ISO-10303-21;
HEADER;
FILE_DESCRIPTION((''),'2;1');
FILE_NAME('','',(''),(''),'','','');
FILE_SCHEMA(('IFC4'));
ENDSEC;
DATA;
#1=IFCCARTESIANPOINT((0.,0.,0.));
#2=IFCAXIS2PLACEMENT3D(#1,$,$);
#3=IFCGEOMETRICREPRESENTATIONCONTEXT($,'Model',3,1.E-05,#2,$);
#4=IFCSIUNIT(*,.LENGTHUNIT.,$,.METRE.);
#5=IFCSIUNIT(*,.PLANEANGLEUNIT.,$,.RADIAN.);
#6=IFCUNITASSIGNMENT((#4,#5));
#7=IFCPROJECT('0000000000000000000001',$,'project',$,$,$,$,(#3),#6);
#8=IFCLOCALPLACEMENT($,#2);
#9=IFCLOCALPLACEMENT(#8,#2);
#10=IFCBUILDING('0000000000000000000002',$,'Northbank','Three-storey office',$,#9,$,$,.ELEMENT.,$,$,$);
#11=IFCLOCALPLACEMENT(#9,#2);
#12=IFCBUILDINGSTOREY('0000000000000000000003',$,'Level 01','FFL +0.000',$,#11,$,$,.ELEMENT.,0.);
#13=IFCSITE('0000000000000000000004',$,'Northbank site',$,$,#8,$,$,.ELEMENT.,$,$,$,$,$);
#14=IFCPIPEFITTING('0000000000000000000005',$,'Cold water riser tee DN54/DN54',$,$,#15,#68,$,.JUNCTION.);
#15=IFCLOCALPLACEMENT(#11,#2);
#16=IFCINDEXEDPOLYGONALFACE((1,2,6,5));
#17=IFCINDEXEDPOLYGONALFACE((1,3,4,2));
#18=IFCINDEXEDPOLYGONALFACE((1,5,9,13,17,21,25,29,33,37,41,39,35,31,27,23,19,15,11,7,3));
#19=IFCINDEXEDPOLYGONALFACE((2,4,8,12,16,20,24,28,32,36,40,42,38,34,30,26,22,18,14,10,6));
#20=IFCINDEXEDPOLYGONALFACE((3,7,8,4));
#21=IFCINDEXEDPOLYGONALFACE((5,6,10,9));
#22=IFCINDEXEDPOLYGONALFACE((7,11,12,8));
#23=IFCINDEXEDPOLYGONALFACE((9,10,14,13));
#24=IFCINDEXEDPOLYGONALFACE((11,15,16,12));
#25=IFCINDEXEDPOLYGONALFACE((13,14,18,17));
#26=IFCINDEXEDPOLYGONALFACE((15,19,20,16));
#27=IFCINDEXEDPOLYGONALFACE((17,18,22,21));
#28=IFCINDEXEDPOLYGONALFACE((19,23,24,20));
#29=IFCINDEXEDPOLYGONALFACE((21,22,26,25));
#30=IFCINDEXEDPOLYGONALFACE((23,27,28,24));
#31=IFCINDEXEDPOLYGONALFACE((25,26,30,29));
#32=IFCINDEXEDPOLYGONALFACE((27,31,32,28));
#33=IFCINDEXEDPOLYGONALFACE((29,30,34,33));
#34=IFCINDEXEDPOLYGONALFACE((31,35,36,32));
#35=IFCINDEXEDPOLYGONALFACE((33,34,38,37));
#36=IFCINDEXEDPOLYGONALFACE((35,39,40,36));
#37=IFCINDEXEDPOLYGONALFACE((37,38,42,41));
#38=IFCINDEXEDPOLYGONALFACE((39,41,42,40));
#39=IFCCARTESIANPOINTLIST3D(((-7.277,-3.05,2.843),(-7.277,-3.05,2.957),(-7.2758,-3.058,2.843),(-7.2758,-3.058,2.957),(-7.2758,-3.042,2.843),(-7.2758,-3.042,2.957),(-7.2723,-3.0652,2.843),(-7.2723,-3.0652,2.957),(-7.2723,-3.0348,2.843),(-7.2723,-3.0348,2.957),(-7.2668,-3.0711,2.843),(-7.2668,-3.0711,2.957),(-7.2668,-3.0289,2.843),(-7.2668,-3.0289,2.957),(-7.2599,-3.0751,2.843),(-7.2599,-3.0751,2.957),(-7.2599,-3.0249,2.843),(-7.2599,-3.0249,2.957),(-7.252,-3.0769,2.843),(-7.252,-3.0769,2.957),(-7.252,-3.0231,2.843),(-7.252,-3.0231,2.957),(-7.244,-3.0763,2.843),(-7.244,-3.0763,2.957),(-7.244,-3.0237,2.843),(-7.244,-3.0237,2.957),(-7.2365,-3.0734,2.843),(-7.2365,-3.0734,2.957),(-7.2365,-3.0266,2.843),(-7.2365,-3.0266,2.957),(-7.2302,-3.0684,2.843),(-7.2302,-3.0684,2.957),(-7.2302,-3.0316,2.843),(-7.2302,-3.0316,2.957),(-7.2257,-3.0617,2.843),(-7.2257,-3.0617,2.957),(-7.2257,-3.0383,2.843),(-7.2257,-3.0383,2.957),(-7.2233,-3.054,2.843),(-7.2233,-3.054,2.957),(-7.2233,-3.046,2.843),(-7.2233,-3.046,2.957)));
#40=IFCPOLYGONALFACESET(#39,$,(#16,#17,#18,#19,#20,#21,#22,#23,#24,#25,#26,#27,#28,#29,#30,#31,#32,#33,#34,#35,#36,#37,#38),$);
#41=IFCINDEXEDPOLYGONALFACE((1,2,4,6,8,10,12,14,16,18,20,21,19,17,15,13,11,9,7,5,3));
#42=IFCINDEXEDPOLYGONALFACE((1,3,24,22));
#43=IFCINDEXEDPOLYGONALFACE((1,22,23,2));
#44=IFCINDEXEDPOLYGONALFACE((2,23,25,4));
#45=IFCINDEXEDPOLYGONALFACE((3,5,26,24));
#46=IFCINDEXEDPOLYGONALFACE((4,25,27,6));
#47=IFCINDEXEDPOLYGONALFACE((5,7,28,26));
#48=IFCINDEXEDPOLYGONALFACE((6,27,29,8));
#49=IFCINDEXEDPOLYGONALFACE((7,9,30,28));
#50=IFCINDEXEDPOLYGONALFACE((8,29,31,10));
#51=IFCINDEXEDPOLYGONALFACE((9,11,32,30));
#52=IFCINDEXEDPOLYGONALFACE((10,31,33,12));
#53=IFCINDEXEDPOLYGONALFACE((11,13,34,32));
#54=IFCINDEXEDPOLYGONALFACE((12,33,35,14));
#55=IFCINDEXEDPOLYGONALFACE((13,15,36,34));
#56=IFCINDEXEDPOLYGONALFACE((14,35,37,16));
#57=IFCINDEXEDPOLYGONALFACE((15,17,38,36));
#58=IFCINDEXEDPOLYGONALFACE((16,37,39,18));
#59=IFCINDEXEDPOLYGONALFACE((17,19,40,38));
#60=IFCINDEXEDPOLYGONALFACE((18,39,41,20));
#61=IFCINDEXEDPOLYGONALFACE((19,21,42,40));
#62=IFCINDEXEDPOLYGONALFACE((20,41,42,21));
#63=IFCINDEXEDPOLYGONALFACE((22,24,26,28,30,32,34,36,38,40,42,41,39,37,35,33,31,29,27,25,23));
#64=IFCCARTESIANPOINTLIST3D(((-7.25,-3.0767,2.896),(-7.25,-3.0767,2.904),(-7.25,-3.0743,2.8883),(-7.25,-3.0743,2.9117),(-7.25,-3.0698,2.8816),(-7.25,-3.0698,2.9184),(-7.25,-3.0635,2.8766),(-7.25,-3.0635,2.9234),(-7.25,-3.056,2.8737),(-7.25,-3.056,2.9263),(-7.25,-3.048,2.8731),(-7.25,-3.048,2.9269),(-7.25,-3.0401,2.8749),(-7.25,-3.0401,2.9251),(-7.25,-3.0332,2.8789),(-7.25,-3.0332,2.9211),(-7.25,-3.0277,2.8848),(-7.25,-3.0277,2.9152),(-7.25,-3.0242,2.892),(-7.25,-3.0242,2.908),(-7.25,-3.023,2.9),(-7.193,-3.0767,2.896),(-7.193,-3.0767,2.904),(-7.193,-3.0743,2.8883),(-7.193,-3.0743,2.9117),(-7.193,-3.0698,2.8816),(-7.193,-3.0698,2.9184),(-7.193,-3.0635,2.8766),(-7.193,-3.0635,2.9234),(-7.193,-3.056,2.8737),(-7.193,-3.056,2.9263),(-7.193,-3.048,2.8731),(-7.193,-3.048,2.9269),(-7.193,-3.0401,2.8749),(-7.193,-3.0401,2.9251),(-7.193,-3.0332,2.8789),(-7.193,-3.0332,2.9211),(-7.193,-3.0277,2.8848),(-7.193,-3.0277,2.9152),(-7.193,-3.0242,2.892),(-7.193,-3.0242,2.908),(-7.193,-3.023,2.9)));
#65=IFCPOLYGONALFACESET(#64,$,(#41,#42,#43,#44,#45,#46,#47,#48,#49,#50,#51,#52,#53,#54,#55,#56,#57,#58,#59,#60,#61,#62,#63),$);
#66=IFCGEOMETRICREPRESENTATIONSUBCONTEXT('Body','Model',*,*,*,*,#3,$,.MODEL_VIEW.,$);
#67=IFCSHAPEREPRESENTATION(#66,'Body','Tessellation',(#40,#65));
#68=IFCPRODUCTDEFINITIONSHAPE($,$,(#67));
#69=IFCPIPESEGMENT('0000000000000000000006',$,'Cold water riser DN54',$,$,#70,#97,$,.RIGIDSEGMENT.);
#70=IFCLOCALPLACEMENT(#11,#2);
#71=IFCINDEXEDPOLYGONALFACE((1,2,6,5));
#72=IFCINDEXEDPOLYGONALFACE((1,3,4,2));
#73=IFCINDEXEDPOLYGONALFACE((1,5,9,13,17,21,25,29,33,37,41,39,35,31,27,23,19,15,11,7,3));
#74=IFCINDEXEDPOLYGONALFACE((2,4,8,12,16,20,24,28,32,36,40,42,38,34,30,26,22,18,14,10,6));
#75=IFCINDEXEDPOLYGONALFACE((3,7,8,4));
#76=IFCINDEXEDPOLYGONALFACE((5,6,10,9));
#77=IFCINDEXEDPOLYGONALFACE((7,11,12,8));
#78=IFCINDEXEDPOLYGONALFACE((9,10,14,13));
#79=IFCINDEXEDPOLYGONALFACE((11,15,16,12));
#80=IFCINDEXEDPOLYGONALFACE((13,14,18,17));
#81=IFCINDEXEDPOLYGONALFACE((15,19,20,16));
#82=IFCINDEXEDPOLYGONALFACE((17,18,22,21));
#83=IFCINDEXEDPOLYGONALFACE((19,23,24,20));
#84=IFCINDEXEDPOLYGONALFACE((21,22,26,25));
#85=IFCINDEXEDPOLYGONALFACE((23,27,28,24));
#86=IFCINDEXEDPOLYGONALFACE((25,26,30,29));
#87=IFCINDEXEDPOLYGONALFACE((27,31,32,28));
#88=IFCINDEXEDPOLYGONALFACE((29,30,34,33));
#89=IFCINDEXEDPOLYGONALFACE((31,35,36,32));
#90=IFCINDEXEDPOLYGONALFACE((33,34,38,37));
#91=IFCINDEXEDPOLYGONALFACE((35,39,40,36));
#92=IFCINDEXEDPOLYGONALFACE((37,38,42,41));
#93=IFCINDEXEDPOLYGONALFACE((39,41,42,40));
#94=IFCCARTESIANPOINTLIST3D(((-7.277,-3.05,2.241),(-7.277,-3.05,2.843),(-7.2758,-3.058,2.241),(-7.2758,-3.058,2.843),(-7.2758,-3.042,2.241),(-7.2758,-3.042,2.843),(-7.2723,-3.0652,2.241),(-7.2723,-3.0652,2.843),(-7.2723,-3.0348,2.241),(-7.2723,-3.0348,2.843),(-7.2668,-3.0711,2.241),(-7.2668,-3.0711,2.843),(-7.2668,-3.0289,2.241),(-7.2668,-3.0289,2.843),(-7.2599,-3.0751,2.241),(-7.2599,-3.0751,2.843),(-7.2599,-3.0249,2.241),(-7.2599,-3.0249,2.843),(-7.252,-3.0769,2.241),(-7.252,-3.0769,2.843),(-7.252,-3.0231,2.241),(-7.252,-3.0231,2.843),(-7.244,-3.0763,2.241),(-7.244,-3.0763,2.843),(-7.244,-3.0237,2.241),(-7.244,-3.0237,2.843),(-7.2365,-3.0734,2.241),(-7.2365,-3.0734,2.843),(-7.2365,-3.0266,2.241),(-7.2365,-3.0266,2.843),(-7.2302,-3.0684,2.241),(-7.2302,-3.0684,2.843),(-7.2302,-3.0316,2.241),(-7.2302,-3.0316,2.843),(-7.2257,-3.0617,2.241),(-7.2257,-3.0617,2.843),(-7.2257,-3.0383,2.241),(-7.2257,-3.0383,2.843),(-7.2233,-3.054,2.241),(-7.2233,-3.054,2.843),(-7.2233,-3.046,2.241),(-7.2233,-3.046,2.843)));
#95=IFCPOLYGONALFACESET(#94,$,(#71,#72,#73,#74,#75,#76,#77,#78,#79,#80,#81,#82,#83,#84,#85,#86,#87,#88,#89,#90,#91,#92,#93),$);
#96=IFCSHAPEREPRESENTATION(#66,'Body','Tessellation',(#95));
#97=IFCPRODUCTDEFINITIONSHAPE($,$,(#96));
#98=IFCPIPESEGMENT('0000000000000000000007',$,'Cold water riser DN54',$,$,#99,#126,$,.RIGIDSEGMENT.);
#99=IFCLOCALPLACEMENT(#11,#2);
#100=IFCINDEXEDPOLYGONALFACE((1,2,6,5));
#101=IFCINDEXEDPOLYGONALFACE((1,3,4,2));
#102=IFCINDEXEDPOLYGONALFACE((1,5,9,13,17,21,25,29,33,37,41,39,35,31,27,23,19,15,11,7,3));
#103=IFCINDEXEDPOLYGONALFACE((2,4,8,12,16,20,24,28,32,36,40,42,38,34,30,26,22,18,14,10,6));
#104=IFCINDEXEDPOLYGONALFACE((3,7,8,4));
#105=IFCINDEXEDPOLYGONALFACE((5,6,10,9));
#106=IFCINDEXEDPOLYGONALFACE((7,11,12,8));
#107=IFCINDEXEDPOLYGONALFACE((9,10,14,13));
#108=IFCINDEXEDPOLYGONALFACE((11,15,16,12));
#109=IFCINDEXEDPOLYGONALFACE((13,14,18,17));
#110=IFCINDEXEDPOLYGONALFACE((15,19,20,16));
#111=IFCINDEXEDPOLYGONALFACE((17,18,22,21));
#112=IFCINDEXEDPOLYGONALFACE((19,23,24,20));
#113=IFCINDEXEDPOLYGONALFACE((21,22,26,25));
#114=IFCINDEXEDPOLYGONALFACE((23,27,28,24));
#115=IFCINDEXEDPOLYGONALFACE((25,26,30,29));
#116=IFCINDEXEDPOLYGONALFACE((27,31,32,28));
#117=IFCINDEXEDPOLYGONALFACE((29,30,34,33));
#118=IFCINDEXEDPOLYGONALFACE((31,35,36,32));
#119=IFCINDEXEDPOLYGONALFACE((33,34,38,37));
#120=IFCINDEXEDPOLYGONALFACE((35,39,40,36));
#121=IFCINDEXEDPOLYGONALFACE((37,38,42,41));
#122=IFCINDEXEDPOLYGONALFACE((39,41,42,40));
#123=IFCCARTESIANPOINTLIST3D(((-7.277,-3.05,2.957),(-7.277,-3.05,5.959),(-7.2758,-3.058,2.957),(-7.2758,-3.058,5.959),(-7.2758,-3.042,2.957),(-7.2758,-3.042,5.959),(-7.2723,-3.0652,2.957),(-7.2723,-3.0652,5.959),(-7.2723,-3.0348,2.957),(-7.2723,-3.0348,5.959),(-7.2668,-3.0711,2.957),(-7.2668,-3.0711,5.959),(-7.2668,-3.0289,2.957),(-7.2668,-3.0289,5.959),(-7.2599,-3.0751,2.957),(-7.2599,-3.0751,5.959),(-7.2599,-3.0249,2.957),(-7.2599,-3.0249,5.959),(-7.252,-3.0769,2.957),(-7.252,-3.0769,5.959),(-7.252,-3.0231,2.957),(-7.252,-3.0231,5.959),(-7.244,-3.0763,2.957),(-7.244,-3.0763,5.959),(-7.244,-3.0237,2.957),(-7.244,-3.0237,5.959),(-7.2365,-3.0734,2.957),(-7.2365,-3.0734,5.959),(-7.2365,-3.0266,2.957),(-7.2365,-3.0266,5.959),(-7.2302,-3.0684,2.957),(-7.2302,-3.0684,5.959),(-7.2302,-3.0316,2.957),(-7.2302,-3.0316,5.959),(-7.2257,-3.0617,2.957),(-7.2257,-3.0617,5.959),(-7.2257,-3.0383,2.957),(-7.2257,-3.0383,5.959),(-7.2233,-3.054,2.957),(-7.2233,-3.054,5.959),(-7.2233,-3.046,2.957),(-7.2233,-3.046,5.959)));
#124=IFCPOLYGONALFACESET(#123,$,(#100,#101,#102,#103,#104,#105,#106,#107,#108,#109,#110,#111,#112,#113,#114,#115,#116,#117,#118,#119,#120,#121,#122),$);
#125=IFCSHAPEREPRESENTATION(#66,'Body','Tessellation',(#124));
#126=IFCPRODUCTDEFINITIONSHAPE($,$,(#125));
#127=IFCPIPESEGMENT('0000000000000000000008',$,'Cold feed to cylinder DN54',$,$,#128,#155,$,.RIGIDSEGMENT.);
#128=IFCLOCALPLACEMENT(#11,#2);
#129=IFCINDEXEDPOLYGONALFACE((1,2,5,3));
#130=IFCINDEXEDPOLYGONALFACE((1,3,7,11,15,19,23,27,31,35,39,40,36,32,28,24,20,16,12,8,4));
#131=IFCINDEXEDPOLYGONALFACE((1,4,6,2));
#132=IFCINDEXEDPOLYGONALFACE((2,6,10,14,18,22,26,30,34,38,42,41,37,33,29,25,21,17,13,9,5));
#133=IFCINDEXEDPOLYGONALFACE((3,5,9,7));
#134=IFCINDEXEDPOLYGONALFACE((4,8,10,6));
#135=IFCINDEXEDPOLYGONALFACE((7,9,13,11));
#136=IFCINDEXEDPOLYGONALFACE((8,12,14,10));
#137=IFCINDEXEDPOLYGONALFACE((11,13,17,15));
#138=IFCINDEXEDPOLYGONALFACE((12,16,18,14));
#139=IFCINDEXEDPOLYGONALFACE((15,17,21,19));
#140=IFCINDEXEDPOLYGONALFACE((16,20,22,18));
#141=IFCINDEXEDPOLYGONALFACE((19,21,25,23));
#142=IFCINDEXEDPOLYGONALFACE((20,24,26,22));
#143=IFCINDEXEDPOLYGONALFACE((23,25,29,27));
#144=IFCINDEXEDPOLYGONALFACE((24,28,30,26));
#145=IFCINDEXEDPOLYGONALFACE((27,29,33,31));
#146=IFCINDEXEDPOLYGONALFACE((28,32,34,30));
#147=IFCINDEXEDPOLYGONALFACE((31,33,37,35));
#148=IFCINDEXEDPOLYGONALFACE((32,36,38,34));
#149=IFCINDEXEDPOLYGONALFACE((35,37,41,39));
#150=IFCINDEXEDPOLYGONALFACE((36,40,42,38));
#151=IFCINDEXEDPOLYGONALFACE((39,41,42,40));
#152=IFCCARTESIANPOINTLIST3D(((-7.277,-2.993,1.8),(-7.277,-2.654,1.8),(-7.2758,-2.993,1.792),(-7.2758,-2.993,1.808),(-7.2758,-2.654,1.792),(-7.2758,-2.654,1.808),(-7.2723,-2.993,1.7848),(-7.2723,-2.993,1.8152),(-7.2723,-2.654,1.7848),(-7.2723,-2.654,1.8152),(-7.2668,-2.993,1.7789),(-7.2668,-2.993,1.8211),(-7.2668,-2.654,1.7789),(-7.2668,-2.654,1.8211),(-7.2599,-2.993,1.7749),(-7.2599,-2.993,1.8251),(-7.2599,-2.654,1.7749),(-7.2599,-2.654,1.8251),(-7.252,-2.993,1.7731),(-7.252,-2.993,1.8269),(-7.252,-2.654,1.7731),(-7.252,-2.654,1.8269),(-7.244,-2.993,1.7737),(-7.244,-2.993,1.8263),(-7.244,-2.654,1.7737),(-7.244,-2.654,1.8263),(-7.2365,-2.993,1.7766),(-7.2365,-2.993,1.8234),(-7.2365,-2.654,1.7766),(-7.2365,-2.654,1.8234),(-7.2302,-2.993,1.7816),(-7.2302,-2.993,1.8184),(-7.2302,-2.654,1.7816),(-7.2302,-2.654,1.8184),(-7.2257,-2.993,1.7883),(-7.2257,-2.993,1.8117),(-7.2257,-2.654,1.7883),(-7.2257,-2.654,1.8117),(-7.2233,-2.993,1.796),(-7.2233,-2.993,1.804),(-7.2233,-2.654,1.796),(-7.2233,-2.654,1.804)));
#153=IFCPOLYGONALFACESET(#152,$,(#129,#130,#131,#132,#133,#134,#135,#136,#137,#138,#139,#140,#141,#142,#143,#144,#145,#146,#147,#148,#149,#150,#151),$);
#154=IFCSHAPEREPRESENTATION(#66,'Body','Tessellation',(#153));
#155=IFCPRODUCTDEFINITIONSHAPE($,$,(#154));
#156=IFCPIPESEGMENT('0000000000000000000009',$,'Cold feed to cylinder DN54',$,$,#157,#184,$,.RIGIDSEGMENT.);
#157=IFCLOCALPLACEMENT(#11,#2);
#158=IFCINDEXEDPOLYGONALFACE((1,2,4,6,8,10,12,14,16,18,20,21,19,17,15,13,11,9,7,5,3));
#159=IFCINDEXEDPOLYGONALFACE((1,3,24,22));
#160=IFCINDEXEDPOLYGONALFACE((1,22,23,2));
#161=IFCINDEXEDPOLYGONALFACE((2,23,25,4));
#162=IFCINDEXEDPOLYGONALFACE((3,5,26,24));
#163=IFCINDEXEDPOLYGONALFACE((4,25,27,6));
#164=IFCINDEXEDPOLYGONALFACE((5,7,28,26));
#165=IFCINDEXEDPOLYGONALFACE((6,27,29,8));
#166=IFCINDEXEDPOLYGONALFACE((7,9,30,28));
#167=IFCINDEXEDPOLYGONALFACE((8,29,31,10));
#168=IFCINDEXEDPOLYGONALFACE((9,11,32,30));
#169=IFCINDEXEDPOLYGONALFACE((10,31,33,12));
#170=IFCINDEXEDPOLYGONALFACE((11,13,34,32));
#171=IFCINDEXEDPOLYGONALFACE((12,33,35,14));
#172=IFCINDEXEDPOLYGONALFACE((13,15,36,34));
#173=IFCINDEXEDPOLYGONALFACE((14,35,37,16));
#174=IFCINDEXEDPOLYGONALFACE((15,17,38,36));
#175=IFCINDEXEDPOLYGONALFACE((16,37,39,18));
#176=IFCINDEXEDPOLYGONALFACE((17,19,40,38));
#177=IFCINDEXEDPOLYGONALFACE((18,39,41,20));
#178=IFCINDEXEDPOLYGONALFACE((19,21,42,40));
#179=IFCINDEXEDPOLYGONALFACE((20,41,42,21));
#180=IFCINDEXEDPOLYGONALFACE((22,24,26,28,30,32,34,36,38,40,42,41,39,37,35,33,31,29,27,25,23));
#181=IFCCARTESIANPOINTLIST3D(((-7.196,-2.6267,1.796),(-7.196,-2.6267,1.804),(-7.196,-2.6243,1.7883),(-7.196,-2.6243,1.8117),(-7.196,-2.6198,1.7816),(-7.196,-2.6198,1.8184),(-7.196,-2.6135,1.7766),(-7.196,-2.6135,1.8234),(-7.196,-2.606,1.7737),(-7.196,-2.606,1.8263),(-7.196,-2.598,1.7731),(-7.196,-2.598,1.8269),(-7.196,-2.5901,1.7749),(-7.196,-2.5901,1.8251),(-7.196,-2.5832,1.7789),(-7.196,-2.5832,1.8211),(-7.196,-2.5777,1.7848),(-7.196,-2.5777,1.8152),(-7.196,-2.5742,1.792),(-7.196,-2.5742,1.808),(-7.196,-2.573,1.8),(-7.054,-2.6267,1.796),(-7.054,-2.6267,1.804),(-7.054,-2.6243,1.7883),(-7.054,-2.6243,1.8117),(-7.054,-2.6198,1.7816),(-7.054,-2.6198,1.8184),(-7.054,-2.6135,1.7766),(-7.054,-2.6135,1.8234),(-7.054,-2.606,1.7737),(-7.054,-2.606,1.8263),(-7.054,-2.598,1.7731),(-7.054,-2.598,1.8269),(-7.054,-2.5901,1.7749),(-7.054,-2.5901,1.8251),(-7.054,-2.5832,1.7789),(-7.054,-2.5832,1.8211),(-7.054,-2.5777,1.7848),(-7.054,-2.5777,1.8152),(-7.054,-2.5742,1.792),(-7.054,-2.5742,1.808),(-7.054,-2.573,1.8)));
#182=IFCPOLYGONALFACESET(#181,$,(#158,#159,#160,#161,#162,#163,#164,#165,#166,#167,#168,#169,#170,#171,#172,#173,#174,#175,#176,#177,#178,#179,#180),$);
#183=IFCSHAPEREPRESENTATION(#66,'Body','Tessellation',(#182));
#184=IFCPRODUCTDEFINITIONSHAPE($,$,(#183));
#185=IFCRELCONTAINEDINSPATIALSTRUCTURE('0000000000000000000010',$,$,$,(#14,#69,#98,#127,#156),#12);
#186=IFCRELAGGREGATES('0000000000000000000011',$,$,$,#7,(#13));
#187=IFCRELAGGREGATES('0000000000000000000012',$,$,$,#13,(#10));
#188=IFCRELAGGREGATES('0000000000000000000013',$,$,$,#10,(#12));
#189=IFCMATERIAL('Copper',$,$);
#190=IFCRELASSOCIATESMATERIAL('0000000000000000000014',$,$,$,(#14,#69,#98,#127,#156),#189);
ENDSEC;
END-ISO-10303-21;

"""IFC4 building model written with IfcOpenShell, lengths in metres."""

from ifc_helpers import new_model, si_unit, frame, origin, place, context, subcontext, project, spatial, circle, extrude, material, element, save


model = new_model("IFC4")

# Units and contexts
model_context = context("Model", 3, precision=1e-05, world=origin())
body_context = subcontext(model_context, "Body", "Model", "MODEL_VIEW")
ifc_project = project(units=[si_unit("LENGTHUNIT", "METRE"), si_unit("PLANEANGLEUNIT", "RADIAN")], contexts=[model_context])

# Site, building, storey
site_placement = place(None, origin())
site = spatial("IfcSite", under=ifc_project, at=site_placement, Name="Northbank site", CompositionType="ELEMENT")
building_placement = place(site_placement, origin())
building = spatial("IfcBuilding", under=site, at=building_placement, Name="Northbank", Description="Three-storey office", CompositionType="ELEMENT")
storey_placement = place(building_placement, origin())
storey = spatial("IfcBuildingStorey", under=building, at=storey_placement, Name="Level 01", Description="FFL +0.000", CompositionType="ELEMENT", Elevation=0.0)

# Shared definitions
ifc_material = material(Name="Copper")

# Pipe fitting
pipe_fitting_1_placement = place(storey_placement, origin())
element("IfcPipeFitting", 1, at=pipe_fitting_1_placement, inside=storey, material=ifc_material, Name="Cold water riser tee DN54/DN54", PredefinedType="JUNCTION", context=body_context, shape_type="SweptSolid", body=[
    extrude(circle(Radius=0.027), frame((-7.25, -3.05, 2.843), z_axis=(0.0, 0.0, 1.0), x_axis=(-1.0, 0.0, 0.0)), (0.0, 0.0, 1.0), 0.114),
    extrude(circle(Radius=0.027), frame((-7.25, -3.05, 2.9), z_axis=(1.0, 0.0, 0.0), x_axis=(0.0, 1.0, 0.0)), (0.0, 0.0, 1.0), 0.057),
])

# Pipe segments
pipe_segment_1_placement = place(storey_placement, origin())
element("IfcPipeSegment", 2, at=pipe_segment_1_placement, inside=storey, material=ifc_material, Name="Cold water riser DN54", PredefinedType="RIGIDSEGMENT", context=body_context, shape_type="SweptSolid", body=[
    extrude(circle(Radius=0.027), frame((-7.25, -3.05, 2.241), z_axis=(0.0, 0.0, 1.0), x_axis=(-1.0, 0.0, 0.0)), (0.0, 0.0, 1.0), 0.602),
])
pipe_segment_2_placement = place(storey_placement, origin())
element("IfcPipeSegment", 3, at=pipe_segment_2_placement, inside=storey, material=ifc_material, Name="Cold water riser DN54", PredefinedType="RIGIDSEGMENT", context=body_context, shape_type="SweptSolid", body=[
    extrude(circle(Radius=0.027), frame((-7.25, -3.05, 2.957), z_axis=(0.0, 0.0, 1.0), x_axis=(-1.0, 0.0, 0.0)), (0.0, 0.0, 1.0), 3.002),
])
pipe_segment_3_placement = place(storey_placement, origin())
element("IfcPipeSegment", 4, at=pipe_segment_3_placement, inside=storey, material=ifc_material, Name="Cold feed to cylinder DN54", PredefinedType="RIGIDSEGMENT", context=body_context, shape_type="SweptSolid", body=[
    extrude(circle(Radius=0.027), frame((-7.25, -2.993, 1.8), z_axis=(0.0, 1.0, 0.0), x_axis=(-1.0, 0.0, 0.0)), (0.0, 0.0, 1.0), 0.339),
])
pipe_segment_4_placement = place(storey_placement, origin())
element("IfcPipeSegment", 5, at=pipe_segment_4_placement, inside=storey, material=ifc_material, Name="Cold feed to cylinder DN54", PredefinedType="RIGIDSEGMENT", context=body_context, shape_type="SweptSolid", body=[
    extrude(circle(Radius=0.027), frame((-7.196, -2.6, 1.8), z_axis=(1.0, 0.0, 0.0), x_axis=(0.0, 1.0, 0.0)), (0.0, 0.0, 1.0), 0.142),
])

save(model, "model.ifc")
